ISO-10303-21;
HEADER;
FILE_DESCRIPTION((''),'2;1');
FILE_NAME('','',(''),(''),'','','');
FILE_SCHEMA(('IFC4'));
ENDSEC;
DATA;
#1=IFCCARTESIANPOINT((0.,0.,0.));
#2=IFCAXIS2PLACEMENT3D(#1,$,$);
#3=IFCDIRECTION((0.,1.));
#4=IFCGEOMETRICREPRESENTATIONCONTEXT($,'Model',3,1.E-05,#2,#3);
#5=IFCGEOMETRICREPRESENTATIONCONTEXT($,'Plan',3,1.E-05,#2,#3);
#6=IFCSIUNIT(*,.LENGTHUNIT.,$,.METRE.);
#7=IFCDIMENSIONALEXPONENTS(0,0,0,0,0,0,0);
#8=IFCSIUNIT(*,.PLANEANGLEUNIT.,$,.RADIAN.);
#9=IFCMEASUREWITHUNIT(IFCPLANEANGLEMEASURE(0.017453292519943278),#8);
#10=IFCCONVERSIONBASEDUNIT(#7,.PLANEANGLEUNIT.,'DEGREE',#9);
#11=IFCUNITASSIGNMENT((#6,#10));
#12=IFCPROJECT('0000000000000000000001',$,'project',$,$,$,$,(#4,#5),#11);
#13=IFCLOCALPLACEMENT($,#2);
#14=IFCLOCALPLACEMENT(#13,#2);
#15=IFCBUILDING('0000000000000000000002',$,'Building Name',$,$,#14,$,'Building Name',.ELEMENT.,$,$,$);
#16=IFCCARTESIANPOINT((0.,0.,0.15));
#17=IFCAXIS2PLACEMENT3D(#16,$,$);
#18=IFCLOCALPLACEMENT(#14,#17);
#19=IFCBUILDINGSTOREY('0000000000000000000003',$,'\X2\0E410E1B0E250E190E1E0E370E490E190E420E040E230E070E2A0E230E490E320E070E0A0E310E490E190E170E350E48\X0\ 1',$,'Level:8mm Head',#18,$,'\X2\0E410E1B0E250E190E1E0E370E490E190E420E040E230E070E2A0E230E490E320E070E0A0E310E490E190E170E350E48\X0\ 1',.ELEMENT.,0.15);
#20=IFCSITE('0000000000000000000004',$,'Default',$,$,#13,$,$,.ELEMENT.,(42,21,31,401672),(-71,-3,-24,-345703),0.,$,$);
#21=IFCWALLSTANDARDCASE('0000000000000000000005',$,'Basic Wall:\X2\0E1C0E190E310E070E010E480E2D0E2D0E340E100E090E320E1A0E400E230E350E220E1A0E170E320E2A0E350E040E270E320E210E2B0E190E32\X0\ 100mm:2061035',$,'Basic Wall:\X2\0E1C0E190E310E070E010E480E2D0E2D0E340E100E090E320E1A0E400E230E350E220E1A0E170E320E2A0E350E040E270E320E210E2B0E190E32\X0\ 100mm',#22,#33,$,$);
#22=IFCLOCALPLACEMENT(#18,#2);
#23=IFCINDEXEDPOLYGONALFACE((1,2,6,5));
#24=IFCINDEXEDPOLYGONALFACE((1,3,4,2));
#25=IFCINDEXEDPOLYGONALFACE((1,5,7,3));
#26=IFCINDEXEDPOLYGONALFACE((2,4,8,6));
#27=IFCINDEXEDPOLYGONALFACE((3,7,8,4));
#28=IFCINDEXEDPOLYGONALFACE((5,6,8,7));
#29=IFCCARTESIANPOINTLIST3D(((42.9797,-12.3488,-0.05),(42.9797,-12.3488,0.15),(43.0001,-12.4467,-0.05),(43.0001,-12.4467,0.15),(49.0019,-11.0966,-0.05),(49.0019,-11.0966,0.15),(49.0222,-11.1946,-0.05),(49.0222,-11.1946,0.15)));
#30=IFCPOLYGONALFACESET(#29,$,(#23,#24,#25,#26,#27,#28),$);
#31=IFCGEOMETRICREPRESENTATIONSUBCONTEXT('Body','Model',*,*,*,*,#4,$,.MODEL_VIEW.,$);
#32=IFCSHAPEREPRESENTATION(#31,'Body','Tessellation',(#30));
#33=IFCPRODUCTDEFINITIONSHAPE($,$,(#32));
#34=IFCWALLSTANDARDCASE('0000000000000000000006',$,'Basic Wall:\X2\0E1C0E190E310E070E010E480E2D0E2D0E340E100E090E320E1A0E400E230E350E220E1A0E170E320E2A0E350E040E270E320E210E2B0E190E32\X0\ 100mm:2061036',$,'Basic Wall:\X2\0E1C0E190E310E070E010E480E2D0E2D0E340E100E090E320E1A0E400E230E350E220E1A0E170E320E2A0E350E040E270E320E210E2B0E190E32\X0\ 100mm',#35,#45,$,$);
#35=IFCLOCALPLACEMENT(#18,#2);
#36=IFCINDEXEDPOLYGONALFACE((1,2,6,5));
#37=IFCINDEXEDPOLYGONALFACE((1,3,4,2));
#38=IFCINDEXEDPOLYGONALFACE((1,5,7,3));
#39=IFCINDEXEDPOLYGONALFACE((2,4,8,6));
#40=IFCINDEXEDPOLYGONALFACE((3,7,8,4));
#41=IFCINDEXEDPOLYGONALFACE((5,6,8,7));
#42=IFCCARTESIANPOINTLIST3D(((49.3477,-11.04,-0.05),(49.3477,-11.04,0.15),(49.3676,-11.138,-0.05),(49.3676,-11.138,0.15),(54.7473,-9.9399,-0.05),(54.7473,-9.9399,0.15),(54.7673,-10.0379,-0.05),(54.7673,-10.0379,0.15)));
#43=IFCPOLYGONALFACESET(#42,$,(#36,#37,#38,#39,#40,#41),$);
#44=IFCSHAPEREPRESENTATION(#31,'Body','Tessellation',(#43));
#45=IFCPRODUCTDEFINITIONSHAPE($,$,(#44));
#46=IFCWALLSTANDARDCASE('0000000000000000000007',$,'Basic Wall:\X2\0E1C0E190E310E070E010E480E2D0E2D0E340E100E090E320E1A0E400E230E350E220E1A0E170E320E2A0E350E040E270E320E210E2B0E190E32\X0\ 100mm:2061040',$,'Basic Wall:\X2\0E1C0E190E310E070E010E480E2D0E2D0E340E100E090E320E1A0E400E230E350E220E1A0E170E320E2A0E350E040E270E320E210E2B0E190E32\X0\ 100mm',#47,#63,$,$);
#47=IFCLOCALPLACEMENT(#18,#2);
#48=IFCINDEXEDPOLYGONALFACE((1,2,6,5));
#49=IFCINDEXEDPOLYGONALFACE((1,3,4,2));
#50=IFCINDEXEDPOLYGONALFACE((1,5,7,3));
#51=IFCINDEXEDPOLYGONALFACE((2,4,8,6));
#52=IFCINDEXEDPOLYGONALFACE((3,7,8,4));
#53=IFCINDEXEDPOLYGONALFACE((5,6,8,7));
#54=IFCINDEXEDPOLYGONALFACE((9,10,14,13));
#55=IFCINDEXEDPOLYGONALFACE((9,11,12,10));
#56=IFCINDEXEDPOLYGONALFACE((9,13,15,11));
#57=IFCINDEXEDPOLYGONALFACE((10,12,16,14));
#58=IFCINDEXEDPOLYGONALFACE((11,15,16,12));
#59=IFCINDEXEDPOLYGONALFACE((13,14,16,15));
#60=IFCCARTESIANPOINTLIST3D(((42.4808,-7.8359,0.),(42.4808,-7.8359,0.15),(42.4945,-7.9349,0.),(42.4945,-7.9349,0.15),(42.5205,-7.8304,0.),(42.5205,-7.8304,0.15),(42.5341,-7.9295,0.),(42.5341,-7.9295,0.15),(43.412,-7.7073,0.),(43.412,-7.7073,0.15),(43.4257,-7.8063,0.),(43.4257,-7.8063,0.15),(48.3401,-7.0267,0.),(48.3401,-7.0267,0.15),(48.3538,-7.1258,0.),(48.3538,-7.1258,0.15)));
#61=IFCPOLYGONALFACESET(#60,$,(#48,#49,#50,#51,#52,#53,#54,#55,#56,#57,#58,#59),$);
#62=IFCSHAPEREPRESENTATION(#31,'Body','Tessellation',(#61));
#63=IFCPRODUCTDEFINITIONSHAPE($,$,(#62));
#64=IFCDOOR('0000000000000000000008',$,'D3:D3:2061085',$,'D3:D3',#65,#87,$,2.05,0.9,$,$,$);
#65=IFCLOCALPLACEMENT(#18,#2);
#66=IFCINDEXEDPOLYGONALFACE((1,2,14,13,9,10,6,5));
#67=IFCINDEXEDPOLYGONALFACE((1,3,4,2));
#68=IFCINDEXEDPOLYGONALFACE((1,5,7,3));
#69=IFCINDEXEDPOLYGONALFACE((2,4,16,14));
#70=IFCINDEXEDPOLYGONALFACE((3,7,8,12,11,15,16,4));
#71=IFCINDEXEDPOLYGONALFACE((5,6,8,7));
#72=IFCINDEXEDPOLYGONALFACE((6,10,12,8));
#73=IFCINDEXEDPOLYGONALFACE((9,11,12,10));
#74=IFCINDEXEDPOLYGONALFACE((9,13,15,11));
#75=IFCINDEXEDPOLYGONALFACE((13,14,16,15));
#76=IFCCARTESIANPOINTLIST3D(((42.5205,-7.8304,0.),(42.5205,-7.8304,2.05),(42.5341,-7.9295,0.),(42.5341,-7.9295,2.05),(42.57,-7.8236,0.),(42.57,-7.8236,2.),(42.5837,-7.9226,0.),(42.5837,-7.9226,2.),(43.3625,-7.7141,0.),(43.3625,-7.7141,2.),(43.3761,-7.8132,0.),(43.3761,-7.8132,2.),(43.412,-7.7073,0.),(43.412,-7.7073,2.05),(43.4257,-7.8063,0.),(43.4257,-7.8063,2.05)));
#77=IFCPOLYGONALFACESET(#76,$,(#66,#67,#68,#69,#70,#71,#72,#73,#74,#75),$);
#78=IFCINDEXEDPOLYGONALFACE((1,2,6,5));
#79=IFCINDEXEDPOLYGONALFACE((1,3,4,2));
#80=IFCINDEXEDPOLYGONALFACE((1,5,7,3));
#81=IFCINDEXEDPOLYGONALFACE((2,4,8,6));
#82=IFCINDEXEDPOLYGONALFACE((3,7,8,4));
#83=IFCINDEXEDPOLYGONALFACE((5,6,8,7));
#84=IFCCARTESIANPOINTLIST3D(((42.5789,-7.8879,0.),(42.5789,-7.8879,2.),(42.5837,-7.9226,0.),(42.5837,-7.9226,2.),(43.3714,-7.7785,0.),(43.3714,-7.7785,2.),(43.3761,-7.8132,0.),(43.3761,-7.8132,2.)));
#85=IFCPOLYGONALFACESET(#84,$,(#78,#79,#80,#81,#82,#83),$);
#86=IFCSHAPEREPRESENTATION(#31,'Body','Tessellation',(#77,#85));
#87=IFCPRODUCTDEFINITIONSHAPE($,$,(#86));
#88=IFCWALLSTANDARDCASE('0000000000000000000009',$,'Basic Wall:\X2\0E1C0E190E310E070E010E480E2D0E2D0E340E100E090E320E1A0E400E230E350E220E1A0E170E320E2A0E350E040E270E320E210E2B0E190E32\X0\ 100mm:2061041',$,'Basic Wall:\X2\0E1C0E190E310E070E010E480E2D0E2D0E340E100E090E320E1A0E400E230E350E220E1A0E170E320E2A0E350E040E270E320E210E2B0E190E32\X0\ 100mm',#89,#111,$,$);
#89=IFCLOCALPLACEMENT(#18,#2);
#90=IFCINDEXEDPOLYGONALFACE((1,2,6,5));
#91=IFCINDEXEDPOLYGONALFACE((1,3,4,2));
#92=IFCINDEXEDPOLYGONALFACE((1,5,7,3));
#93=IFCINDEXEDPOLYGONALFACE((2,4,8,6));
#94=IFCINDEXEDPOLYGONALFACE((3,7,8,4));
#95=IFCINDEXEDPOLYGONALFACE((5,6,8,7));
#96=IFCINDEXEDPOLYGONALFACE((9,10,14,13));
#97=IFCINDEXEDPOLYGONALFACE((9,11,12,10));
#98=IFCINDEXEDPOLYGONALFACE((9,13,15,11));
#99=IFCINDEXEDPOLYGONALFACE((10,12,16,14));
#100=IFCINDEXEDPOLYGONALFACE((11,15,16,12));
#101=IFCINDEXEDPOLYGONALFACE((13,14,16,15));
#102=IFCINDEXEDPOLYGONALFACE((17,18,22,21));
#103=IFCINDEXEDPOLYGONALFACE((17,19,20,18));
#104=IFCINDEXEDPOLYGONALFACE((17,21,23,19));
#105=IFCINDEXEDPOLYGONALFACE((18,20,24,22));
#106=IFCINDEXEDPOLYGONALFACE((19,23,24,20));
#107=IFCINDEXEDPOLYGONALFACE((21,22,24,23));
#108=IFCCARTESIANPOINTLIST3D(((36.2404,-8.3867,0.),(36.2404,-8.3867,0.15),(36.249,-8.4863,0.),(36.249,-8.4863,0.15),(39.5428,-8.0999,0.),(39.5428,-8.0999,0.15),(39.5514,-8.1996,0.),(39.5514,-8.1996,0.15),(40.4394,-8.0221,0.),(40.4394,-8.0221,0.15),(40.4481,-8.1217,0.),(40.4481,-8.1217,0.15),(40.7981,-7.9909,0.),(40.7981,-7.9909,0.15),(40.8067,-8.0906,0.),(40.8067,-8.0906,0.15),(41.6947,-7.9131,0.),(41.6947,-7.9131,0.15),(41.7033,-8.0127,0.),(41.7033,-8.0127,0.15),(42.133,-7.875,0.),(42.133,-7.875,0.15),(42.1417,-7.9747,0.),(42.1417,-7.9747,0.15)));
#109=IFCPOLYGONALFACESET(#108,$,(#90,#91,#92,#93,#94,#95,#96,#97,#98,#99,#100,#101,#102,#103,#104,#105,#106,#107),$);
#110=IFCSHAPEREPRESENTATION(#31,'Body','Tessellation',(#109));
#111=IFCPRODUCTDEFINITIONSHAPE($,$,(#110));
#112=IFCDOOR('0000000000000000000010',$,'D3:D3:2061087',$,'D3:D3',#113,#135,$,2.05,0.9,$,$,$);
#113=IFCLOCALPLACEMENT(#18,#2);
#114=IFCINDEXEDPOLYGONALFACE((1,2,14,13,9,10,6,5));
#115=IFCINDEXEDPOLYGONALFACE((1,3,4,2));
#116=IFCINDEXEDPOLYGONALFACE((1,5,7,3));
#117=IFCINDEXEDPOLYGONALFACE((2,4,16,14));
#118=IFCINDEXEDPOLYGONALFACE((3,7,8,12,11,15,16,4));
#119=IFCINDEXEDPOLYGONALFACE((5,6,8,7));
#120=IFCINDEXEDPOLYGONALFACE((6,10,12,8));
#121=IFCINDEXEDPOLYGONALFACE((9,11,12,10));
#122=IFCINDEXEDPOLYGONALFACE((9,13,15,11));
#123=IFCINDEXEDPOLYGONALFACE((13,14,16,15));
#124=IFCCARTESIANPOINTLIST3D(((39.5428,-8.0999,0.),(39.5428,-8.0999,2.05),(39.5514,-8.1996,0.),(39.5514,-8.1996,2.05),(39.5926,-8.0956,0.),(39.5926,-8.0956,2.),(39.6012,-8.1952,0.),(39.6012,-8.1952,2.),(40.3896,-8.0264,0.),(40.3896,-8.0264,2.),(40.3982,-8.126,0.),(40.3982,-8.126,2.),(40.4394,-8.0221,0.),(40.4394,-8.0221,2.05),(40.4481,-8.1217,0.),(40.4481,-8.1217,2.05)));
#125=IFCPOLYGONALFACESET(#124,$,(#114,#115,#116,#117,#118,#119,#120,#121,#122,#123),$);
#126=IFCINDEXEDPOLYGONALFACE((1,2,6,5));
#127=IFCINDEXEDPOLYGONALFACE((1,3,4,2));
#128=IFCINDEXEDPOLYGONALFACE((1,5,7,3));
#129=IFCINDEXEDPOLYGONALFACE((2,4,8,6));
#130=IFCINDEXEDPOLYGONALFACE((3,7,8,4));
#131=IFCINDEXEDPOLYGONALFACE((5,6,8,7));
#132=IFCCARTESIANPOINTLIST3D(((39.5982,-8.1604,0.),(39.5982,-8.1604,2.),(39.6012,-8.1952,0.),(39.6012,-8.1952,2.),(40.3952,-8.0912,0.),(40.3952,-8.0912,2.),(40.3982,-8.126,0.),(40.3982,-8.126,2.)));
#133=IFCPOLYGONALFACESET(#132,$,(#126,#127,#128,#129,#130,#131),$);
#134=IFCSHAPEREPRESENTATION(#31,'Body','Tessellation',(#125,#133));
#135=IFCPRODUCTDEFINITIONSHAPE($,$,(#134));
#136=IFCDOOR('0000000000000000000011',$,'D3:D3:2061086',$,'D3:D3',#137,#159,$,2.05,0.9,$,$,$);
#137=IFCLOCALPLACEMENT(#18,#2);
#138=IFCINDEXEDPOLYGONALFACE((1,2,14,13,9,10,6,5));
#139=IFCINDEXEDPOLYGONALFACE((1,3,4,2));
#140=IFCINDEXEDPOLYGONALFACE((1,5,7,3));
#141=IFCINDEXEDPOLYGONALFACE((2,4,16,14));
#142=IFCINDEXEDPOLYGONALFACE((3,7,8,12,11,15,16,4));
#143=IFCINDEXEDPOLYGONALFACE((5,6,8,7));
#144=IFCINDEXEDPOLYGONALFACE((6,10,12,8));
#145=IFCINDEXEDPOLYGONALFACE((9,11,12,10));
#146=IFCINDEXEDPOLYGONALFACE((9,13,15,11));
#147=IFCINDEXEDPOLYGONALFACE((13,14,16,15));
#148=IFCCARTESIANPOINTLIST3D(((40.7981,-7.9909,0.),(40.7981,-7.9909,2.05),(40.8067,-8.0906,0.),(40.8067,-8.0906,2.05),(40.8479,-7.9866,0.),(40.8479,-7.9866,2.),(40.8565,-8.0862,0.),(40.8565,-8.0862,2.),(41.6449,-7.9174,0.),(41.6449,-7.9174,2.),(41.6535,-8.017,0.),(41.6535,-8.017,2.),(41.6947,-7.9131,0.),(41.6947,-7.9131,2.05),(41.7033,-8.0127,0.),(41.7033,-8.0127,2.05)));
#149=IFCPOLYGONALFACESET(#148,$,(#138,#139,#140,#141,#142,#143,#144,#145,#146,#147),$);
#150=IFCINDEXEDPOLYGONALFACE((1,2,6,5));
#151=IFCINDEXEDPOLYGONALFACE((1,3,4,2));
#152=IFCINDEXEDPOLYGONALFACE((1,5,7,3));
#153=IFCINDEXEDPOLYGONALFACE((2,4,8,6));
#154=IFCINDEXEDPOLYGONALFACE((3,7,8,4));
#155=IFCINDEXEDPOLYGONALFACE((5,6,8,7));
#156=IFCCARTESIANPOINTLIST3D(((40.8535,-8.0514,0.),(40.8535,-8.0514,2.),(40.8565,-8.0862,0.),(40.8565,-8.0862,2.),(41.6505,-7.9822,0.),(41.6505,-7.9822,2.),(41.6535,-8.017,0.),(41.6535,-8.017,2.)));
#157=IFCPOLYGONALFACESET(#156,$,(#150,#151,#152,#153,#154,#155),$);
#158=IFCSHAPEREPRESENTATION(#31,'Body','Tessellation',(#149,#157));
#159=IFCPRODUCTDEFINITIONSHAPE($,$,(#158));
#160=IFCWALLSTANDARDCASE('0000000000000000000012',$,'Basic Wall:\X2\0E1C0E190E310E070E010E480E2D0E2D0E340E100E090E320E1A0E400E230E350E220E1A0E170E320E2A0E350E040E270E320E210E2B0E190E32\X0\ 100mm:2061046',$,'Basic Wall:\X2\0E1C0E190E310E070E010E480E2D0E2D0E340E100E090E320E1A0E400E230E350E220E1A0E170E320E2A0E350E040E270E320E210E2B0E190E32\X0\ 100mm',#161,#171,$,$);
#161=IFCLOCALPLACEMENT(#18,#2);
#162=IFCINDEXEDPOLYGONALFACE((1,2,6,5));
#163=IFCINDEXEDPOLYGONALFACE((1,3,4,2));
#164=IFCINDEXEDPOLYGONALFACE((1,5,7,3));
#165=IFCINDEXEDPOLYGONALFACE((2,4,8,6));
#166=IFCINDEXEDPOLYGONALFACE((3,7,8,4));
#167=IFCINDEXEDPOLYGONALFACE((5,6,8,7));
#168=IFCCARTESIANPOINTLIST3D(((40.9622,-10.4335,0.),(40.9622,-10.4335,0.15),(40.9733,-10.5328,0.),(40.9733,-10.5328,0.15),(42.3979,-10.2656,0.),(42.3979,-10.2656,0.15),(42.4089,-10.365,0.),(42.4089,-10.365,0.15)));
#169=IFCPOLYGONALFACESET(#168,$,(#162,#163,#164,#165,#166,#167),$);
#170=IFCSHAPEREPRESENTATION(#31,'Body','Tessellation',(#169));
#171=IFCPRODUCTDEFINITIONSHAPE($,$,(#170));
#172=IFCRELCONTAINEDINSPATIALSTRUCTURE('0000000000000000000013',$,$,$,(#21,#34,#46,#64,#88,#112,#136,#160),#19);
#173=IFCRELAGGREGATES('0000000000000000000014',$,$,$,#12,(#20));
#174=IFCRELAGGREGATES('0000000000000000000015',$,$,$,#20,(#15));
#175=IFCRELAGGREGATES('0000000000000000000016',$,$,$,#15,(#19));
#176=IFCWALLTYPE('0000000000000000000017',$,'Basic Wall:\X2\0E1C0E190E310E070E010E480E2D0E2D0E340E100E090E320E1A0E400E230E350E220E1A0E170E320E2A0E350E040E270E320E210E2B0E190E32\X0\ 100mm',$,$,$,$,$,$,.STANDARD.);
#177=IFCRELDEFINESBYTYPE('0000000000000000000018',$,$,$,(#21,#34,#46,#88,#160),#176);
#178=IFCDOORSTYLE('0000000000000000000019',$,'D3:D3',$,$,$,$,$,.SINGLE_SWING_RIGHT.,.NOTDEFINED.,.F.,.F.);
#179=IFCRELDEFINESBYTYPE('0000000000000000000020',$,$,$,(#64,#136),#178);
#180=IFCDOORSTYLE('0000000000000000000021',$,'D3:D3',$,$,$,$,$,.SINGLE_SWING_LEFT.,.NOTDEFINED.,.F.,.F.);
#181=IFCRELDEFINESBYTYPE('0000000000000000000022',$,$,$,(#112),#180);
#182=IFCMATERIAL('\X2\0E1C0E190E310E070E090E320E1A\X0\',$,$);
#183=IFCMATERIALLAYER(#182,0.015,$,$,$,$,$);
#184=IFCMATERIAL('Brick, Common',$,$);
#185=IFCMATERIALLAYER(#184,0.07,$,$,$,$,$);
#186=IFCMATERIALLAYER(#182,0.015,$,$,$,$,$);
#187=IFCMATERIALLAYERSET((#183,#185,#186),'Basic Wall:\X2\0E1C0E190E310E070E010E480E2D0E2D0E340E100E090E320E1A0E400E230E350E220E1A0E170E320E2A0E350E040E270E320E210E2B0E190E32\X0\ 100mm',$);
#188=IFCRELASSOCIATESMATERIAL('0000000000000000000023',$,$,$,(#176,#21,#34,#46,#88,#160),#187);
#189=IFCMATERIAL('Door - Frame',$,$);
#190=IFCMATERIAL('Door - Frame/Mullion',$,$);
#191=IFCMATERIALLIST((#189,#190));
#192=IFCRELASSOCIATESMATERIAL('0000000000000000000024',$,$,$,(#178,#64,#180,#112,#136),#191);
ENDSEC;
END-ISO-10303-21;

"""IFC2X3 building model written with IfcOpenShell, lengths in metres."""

from ifc_helpers import new_model, entity, si_unit, converted_unit, direction, frame, frame_2d, origin, origin_2d_with_axis, place, context, subcontext, project, spatial, polyline, rectangle, outline, extrude, clip, halfspace, source, transform, mapped, material, material_list, layer, layer_set, layer_usage, type_object, type_shapes, element, fill, save


model = new_model("IFC2X3")

# Units and contexts
model_context = context("Model", 3, precision=1e-05, world=origin(), true_north=direction((0.0, 1.0)))
plan_context = context("Plan", 3, precision=1e-05, world=origin(), true_north=direction((0.0, 1.0)))
body_context = subcontext(model_context, "Body", "Model", "MODEL_VIEW")
ifc_project = project(units=[si_unit("LENGTHUNIT", "METRE"), converted_unit("PLANEANGLEUNIT", "DEGREE", entity("IfcPlaneAngleMeasure", 0.017453292519943278), si_unit("PLANEANGLEUNIT", "RADIAN"), dimensions=[0, 0, 0, 0, 0, 0, 0])], contexts=[model_context, plan_context])

# Site, building, storey
site_placement = place(None, origin())
site = spatial("IfcSite", under=ifc_project, at=site_placement, Name="Default", CompositionType="ELEMENT", RefLatitude=(42, 21, 31, 401672), RefLongitude=(-71, -3, -24, -345703), RefElevation=0.0)
building_placement = place(site_placement, origin())
building = spatial("IfcBuilding", under=site, at=building_placement, Name="Building Name", LongName="Building Name", CompositionType="ELEMENT")
storey_placement = place(building_placement, frame((0.0, 0.0, 0.15)))
storey = spatial("IfcBuildingStorey", under=building, at=storey_placement, Name="แปลนพื้นโครงสร้างชั้นที่ 1", ObjectType="Level:8mm Head", LongName="แปลนพื้นโครงสร้างชั้นที่ 1", CompositionType="ELEMENT", Elevation=0.15)

# Walls
ifc_material_1 = material(Name="ผนังฉาบ")
ifc_layer_1 = layer(ifc_material_1, 0.015)
ifc_material_2 = material(Name="Brick, Common")
ifc_layer_2 = layer(ifc_material_2, 0.07)
ifc_layer_3 = layer(ifc_material_1, 0.015)
ifc_layer_set = layer_set([ifc_layer_1, ifc_layer_2, ifc_layer_3], Name="Basic Wall:ผนังก่ออิฐฉาบเรียบทาสีความหนา 100mm")
ifc_layer_usage_1 = layer_usage(ifc_layer_set, "AXIS2", "POSITIVE", -0.05)
wall_type = type_object("IfcWallType", Name="Basic Wall:ผนังก่ออิฐฉาบเรียบทาสีความหนา 100mm", PredefinedType="STANDARD", material=ifc_layer_set)
wall_1_placement = place(storey_placement, frame((42.9899, -12.3978, -0.05), z_axis=(0.0, 0.0, 1.0), x_axis=(0.97906, 0.203573, 0.0)))
element("IfcWallStandardCase", 1, at=wall_1_placement, inside=storey, type_object=wall_type, material=ifc_layer_usage_1, Name="Basic Wall:ผนังก่ออิฐฉาบเรียบทาสีความหนา 100mm:2061035", ObjectType="Basic Wall:ผนังก่ออิฐฉาบเรียบทาสีความหนา 100mm", context=body_context, shape_type="Clipping", body=[
    clip(extrude(rectangle(XDim=6.151, YDim=0.1, at=frame_2d((3.0755, 0.0), x_axis=(-1.0, 0.0))), origin(), (0.0, 0.0, 1.0), 0.2), halfspace(frame((0.0, 0.0, -0.05)), True)),
])
ifc_layer_usage_2 = layer_usage(ifc_layer_set, "AXIS2", "POSITIVE", -0.05)
wall_2_placement = place(storey_placement, frame((49.3577, -11.089, -0.05), z_axis=(0.0, 0.0, 1.0), x_axis=(0.979871, 0.199633, 0.0)))
element("IfcWallStandardCase", 2, at=wall_2_placement, inside=storey, type_object=wall_type, material=ifc_layer_usage_2, Name="Basic Wall:ผนังก่ออิฐฉาบเรียบทาสีความหนา 100mm:2061036", ObjectType="Basic Wall:ผนังก่ออิฐฉาบเรียบทาสีความหนา 100mm", context=body_context, shape_type="Clipping", body=[
    clip(extrude(rectangle(XDim=5.5105, YDim=0.1, at=frame_2d((2.7553, 0.0), x_axis=(-1.0, 0.0))), origin(), (0.0, 0.0, 1.0), 0.2), halfspace(frame((0.0, 0.0, -0.05)), True)),
])

# Wall, opening, door
ifc_layer_usage_3 = layer_usage(ifc_layer_set, "AXIS2", "POSITIVE", -0.05)
wall_3_placement = place(storey_placement, frame((48.347, -7.0763, 0.0), z_axis=(0.0, 0.0, 1.0), x_axis=(-0.990599, -0.136795, 0.0)))
wall_3 = element("IfcWallStandardCase", 3, at=wall_3_placement, inside=storey, type_object=wall_type, material=ifc_layer_usage_3, Name="Basic Wall:ผนังก่ออิฐฉาบเรียบทาสีความหนา 100mm:2061040", ObjectType="Basic Wall:ผนังก่ออิฐฉาบเรียบทาสีความหนา 100mm", context=body_context, shape_type="Clipping", body=[
    clip(extrude(rectangle(XDim=5.9149, YDim=0.1, at=frame_2d((2.9575, 0.0), x_axis=(1.0, 0.0))), origin(), (0.0, 0.0, 1.0), 0.15), halfspace(origin(), True)),
])
opening_1_placement = place(wall_3_placement, frame((4.9749, -0.05, 0.0)))
opening_1 = element("IfcOpeningElement", 4, at=opening_1_placement, cuts=wall_3, ObjectType="Opening", context=body_context, shape_type="SweptSolid", body=[
    extrude(rectangle(XDim=2.05, YDim=0.9, at=frame_2d((1.025, 0.45), x_axis=(1.0, 0.0))), frame((0.0, 0.0, 0.0), z_axis=(0.0, 1.0, 0.0), x_axis=(0.0, 0.0, 1.0)), (0.0, 0.0, 1.0), 0.1),
])
ifc_material_3 = material(Name="Door - Frame")
ifc_material_4 = material(Name="Door - Frame/Mullion")
ifc_material_list = material_list([ifc_material_3, ifc_material_4])
door_style_1 = type_object("IfcDoorStyle", Name="D3:D3", ConstructionType="NOTDEFINED", OperationType="SINGLE_SWING_RIGHT", ParameterTakesPrecedence=False, Sizeable=False, material=ifc_material_list)
shared_shape_1 = source(origin(), body_context, "Body", "SweptSolid", [
    extrude(outline(polyline([(-0.45, -1.0125), (-0.4, -1.0125), (-0.4, 0.9875), (0.4, 0.9875), (0.4, -1.0125), (0.45, -1.0125), (0.45, 1.0375), (-0.45, 1.0375), (-0.45, -1.0125)])), frame((0.45, 0.1, 1.0125), z_axis=(0.0, -1.0, 0.0), x_axis=(1.0, 0.0, 0.0)), (0.0, 0.0, 1.0), 0.1),
    extrude(rectangle(XDim=0.035, YDim=0.8, at=origin_2d_with_axis()), frame((0.45, 0.0825, 0.0), z_axis=(0.0, 0.0, 1.0), x_axis=(0.0, -1.0, 0.0)), (0.0, 0.0, 1.0), 2.0),
])
type_shapes(door_style_1, [shared_shape_1])
door_1_placement = place(opening_1_placement, origin())
door_1 = element("IfcDoor", 5, at=door_1_placement, inside=storey, type_object=door_style_1, material=ifc_material_list, Name="D3:D3:2061085", ObjectType="D3:D3", OverallHeight=2.05, OverallWidth=0.9, context=body_context, shape_type="MappedRepresentation", body=[
    mapped(shared_shape_1, transform((0.0, 0.0, 0.0), scale=1.0)),
])
fill(opening_1, door_1)

# Wall, openings, doors
ifc_layer_usage_4 = layer_usage(ifc_layer_set, "AXIS2", "POSITIVE", -0.05)
wall_4_placement = place(storey_placement, frame((42.1374, -7.9248, 0.0), z_axis=(0.0, 0.0, 1.0), x_axis=(-0.996252, -0.086502, 0.0)))
wall_4 = element("IfcWallStandardCase", 6, at=wall_4_placement, inside=storey, type_object=wall_type, material=ifc_layer_usage_4, Name="Basic Wall:ผนังก่ออิฐฉาบเรียบทาสีความหนา 100mm:2061041", ObjectType="Basic Wall:ผนังก่ออิฐฉาบเรียบทาสีความหนา 100mm", context=body_context, shape_type="Clipping", body=[
    clip(extrude(rectangle(XDim=5.9148, YDim=0.1, at=frame_2d((2.9574, 0.0), x_axis=(1.0, 0.0))), origin(), (0.0, 0.0, 1.0), 0.15), halfspace(origin(), True)),
])
opening_2_placement = place(wall_4_placement, frame((0.44, -0.05, 0.0)))
opening_2 = element("IfcOpeningElement", 7, at=opening_2_placement, cuts=wall_4, ObjectType="Opening", context=body_context, shape_type="SweptSolid", body=[
    extrude(rectangle(XDim=2.05, YDim=0.9, at=frame_2d((1.025, 0.45), x_axis=(1.0, 0.0))), frame((0.0, 0.0, 0.0), z_axis=(0.0, 1.0, 0.0), x_axis=(0.0, 0.0, 1.0)), (0.0, 0.0, 1.0), 0.1),
])
opening_3_placement = place(wall_4_placement, frame((1.7, -0.05, 0.0)))
opening_3 = element("IfcOpeningElement", 8, at=opening_3_placement, cuts=wall_4, ObjectType="Opening", context=body_context, shape_type="SweptSolid", body=[
    extrude(rectangle(XDim=2.05, YDim=0.9, at=frame_2d((1.025, 0.45), x_axis=(1.0, 0.0))), frame((0.0, 0.0, 0.0), z_axis=(0.0, 1.0, 0.0), x_axis=(0.0, 0.0, 1.0)), (0.0, 0.0, 1.0), 0.1),
])
door_style_2 = type_object("IfcDoorStyle", Name="D3:D3", ConstructionType="NOTDEFINED", OperationType="SINGLE_SWING_LEFT", ParameterTakesPrecedence=False, Sizeable=False, material=ifc_material_list)
shared_shape_2 = source(origin(), body_context, "Body", "SweptSolid", [
    extrude(outline(polyline([(-1.0125, -0.4), (-1.0125, -0.45), (1.0375, -0.45), (1.0375, 0.45), (-1.0125, 0.45), (-1.0125, 0.4), (0.9875, 0.4), (0.9875, -0.4), (-1.0125, -0.4)])), frame((0.45, 0.0, 1.0125), z_axis=(0.0, -1.0, 0.0), x_axis=(0.0, 0.0, 1.0)), (0.0, 0.0, -1.0), 0.1),
    extrude(rectangle(XDim=0.8, YDim=0.035, at=origin_2d_with_axis()), frame((0.45, 0.0825, 0.0), z_axis=(0.0, 0.0, 1.0), x_axis=(-1.0, 0.0, 0.0)), (0.0, 0.0, 1.0), 2.0),
])
type_shapes(door_style_2, [shared_shape_2])
door_2_placement = place(opening_3_placement, origin())
door_2 = element("IfcDoor", 9, at=door_2_placement, inside=storey, type_object=door_style_2, material=ifc_material_list, Name="D3:D3:2061087", ObjectType="D3:D3", OverallHeight=2.05, OverallWidth=0.9, context=body_context, shape_type="MappedRepresentation", body=[
    mapped(shared_shape_2, transform((0.0, 0.0, 0.0), scale=1.0)),
])
fill(opening_3, door_2)
door_3_placement = place(opening_2_placement, origin())
door_3 = element("IfcDoor", 10, at=door_3_placement, inside=storey, type_object=door_style_1, material=ifc_material_list, Name="D3:D3:2061086", ObjectType="D3:D3", OverallHeight=2.05, OverallWidth=0.9, context=body_context, shape_type="MappedRepresentation", body=[
    mapped(shared_shape_1, transform((0.0, 0.0, 0.0), scale=1.0)),
])
fill(opening_2, door_3)

# Wall
ifc_layer_usage_5 = layer_usage(ifc_layer_set, "AXIS2", "POSITIVE", -0.05)
wall_5_placement = place(storey_placement, frame((40.9675, -10.4832, 0.0), z_axis=(0.0, 0.0, 1.0), x_axis=(0.993236, 0.116115, 0.0)))
element("IfcWallStandardCase", 11, at=wall_5_placement, inside=storey, type_object=wall_type, material=ifc_layer_usage_5, Name="Basic Wall:ผนังก่ออิฐฉาบเรียบทาสีความหนา 100mm:2061046", ObjectType="Basic Wall:ผนังก่ออิฐฉาบเรียบทาสีความหนา 100mm", context=body_context, shape_type="Clipping", body=[
    clip(extrude(outline(polyline([(1.4453, -0.05), (1.4459, 0.05), (0.0004, 0.05), (0.0, -0.05), (1.4453, -0.05)])), origin(), (0.0, 0.0, 1.0), 0.15), halfspace(origin(), True)),
])

save(model, "model.ifc")
